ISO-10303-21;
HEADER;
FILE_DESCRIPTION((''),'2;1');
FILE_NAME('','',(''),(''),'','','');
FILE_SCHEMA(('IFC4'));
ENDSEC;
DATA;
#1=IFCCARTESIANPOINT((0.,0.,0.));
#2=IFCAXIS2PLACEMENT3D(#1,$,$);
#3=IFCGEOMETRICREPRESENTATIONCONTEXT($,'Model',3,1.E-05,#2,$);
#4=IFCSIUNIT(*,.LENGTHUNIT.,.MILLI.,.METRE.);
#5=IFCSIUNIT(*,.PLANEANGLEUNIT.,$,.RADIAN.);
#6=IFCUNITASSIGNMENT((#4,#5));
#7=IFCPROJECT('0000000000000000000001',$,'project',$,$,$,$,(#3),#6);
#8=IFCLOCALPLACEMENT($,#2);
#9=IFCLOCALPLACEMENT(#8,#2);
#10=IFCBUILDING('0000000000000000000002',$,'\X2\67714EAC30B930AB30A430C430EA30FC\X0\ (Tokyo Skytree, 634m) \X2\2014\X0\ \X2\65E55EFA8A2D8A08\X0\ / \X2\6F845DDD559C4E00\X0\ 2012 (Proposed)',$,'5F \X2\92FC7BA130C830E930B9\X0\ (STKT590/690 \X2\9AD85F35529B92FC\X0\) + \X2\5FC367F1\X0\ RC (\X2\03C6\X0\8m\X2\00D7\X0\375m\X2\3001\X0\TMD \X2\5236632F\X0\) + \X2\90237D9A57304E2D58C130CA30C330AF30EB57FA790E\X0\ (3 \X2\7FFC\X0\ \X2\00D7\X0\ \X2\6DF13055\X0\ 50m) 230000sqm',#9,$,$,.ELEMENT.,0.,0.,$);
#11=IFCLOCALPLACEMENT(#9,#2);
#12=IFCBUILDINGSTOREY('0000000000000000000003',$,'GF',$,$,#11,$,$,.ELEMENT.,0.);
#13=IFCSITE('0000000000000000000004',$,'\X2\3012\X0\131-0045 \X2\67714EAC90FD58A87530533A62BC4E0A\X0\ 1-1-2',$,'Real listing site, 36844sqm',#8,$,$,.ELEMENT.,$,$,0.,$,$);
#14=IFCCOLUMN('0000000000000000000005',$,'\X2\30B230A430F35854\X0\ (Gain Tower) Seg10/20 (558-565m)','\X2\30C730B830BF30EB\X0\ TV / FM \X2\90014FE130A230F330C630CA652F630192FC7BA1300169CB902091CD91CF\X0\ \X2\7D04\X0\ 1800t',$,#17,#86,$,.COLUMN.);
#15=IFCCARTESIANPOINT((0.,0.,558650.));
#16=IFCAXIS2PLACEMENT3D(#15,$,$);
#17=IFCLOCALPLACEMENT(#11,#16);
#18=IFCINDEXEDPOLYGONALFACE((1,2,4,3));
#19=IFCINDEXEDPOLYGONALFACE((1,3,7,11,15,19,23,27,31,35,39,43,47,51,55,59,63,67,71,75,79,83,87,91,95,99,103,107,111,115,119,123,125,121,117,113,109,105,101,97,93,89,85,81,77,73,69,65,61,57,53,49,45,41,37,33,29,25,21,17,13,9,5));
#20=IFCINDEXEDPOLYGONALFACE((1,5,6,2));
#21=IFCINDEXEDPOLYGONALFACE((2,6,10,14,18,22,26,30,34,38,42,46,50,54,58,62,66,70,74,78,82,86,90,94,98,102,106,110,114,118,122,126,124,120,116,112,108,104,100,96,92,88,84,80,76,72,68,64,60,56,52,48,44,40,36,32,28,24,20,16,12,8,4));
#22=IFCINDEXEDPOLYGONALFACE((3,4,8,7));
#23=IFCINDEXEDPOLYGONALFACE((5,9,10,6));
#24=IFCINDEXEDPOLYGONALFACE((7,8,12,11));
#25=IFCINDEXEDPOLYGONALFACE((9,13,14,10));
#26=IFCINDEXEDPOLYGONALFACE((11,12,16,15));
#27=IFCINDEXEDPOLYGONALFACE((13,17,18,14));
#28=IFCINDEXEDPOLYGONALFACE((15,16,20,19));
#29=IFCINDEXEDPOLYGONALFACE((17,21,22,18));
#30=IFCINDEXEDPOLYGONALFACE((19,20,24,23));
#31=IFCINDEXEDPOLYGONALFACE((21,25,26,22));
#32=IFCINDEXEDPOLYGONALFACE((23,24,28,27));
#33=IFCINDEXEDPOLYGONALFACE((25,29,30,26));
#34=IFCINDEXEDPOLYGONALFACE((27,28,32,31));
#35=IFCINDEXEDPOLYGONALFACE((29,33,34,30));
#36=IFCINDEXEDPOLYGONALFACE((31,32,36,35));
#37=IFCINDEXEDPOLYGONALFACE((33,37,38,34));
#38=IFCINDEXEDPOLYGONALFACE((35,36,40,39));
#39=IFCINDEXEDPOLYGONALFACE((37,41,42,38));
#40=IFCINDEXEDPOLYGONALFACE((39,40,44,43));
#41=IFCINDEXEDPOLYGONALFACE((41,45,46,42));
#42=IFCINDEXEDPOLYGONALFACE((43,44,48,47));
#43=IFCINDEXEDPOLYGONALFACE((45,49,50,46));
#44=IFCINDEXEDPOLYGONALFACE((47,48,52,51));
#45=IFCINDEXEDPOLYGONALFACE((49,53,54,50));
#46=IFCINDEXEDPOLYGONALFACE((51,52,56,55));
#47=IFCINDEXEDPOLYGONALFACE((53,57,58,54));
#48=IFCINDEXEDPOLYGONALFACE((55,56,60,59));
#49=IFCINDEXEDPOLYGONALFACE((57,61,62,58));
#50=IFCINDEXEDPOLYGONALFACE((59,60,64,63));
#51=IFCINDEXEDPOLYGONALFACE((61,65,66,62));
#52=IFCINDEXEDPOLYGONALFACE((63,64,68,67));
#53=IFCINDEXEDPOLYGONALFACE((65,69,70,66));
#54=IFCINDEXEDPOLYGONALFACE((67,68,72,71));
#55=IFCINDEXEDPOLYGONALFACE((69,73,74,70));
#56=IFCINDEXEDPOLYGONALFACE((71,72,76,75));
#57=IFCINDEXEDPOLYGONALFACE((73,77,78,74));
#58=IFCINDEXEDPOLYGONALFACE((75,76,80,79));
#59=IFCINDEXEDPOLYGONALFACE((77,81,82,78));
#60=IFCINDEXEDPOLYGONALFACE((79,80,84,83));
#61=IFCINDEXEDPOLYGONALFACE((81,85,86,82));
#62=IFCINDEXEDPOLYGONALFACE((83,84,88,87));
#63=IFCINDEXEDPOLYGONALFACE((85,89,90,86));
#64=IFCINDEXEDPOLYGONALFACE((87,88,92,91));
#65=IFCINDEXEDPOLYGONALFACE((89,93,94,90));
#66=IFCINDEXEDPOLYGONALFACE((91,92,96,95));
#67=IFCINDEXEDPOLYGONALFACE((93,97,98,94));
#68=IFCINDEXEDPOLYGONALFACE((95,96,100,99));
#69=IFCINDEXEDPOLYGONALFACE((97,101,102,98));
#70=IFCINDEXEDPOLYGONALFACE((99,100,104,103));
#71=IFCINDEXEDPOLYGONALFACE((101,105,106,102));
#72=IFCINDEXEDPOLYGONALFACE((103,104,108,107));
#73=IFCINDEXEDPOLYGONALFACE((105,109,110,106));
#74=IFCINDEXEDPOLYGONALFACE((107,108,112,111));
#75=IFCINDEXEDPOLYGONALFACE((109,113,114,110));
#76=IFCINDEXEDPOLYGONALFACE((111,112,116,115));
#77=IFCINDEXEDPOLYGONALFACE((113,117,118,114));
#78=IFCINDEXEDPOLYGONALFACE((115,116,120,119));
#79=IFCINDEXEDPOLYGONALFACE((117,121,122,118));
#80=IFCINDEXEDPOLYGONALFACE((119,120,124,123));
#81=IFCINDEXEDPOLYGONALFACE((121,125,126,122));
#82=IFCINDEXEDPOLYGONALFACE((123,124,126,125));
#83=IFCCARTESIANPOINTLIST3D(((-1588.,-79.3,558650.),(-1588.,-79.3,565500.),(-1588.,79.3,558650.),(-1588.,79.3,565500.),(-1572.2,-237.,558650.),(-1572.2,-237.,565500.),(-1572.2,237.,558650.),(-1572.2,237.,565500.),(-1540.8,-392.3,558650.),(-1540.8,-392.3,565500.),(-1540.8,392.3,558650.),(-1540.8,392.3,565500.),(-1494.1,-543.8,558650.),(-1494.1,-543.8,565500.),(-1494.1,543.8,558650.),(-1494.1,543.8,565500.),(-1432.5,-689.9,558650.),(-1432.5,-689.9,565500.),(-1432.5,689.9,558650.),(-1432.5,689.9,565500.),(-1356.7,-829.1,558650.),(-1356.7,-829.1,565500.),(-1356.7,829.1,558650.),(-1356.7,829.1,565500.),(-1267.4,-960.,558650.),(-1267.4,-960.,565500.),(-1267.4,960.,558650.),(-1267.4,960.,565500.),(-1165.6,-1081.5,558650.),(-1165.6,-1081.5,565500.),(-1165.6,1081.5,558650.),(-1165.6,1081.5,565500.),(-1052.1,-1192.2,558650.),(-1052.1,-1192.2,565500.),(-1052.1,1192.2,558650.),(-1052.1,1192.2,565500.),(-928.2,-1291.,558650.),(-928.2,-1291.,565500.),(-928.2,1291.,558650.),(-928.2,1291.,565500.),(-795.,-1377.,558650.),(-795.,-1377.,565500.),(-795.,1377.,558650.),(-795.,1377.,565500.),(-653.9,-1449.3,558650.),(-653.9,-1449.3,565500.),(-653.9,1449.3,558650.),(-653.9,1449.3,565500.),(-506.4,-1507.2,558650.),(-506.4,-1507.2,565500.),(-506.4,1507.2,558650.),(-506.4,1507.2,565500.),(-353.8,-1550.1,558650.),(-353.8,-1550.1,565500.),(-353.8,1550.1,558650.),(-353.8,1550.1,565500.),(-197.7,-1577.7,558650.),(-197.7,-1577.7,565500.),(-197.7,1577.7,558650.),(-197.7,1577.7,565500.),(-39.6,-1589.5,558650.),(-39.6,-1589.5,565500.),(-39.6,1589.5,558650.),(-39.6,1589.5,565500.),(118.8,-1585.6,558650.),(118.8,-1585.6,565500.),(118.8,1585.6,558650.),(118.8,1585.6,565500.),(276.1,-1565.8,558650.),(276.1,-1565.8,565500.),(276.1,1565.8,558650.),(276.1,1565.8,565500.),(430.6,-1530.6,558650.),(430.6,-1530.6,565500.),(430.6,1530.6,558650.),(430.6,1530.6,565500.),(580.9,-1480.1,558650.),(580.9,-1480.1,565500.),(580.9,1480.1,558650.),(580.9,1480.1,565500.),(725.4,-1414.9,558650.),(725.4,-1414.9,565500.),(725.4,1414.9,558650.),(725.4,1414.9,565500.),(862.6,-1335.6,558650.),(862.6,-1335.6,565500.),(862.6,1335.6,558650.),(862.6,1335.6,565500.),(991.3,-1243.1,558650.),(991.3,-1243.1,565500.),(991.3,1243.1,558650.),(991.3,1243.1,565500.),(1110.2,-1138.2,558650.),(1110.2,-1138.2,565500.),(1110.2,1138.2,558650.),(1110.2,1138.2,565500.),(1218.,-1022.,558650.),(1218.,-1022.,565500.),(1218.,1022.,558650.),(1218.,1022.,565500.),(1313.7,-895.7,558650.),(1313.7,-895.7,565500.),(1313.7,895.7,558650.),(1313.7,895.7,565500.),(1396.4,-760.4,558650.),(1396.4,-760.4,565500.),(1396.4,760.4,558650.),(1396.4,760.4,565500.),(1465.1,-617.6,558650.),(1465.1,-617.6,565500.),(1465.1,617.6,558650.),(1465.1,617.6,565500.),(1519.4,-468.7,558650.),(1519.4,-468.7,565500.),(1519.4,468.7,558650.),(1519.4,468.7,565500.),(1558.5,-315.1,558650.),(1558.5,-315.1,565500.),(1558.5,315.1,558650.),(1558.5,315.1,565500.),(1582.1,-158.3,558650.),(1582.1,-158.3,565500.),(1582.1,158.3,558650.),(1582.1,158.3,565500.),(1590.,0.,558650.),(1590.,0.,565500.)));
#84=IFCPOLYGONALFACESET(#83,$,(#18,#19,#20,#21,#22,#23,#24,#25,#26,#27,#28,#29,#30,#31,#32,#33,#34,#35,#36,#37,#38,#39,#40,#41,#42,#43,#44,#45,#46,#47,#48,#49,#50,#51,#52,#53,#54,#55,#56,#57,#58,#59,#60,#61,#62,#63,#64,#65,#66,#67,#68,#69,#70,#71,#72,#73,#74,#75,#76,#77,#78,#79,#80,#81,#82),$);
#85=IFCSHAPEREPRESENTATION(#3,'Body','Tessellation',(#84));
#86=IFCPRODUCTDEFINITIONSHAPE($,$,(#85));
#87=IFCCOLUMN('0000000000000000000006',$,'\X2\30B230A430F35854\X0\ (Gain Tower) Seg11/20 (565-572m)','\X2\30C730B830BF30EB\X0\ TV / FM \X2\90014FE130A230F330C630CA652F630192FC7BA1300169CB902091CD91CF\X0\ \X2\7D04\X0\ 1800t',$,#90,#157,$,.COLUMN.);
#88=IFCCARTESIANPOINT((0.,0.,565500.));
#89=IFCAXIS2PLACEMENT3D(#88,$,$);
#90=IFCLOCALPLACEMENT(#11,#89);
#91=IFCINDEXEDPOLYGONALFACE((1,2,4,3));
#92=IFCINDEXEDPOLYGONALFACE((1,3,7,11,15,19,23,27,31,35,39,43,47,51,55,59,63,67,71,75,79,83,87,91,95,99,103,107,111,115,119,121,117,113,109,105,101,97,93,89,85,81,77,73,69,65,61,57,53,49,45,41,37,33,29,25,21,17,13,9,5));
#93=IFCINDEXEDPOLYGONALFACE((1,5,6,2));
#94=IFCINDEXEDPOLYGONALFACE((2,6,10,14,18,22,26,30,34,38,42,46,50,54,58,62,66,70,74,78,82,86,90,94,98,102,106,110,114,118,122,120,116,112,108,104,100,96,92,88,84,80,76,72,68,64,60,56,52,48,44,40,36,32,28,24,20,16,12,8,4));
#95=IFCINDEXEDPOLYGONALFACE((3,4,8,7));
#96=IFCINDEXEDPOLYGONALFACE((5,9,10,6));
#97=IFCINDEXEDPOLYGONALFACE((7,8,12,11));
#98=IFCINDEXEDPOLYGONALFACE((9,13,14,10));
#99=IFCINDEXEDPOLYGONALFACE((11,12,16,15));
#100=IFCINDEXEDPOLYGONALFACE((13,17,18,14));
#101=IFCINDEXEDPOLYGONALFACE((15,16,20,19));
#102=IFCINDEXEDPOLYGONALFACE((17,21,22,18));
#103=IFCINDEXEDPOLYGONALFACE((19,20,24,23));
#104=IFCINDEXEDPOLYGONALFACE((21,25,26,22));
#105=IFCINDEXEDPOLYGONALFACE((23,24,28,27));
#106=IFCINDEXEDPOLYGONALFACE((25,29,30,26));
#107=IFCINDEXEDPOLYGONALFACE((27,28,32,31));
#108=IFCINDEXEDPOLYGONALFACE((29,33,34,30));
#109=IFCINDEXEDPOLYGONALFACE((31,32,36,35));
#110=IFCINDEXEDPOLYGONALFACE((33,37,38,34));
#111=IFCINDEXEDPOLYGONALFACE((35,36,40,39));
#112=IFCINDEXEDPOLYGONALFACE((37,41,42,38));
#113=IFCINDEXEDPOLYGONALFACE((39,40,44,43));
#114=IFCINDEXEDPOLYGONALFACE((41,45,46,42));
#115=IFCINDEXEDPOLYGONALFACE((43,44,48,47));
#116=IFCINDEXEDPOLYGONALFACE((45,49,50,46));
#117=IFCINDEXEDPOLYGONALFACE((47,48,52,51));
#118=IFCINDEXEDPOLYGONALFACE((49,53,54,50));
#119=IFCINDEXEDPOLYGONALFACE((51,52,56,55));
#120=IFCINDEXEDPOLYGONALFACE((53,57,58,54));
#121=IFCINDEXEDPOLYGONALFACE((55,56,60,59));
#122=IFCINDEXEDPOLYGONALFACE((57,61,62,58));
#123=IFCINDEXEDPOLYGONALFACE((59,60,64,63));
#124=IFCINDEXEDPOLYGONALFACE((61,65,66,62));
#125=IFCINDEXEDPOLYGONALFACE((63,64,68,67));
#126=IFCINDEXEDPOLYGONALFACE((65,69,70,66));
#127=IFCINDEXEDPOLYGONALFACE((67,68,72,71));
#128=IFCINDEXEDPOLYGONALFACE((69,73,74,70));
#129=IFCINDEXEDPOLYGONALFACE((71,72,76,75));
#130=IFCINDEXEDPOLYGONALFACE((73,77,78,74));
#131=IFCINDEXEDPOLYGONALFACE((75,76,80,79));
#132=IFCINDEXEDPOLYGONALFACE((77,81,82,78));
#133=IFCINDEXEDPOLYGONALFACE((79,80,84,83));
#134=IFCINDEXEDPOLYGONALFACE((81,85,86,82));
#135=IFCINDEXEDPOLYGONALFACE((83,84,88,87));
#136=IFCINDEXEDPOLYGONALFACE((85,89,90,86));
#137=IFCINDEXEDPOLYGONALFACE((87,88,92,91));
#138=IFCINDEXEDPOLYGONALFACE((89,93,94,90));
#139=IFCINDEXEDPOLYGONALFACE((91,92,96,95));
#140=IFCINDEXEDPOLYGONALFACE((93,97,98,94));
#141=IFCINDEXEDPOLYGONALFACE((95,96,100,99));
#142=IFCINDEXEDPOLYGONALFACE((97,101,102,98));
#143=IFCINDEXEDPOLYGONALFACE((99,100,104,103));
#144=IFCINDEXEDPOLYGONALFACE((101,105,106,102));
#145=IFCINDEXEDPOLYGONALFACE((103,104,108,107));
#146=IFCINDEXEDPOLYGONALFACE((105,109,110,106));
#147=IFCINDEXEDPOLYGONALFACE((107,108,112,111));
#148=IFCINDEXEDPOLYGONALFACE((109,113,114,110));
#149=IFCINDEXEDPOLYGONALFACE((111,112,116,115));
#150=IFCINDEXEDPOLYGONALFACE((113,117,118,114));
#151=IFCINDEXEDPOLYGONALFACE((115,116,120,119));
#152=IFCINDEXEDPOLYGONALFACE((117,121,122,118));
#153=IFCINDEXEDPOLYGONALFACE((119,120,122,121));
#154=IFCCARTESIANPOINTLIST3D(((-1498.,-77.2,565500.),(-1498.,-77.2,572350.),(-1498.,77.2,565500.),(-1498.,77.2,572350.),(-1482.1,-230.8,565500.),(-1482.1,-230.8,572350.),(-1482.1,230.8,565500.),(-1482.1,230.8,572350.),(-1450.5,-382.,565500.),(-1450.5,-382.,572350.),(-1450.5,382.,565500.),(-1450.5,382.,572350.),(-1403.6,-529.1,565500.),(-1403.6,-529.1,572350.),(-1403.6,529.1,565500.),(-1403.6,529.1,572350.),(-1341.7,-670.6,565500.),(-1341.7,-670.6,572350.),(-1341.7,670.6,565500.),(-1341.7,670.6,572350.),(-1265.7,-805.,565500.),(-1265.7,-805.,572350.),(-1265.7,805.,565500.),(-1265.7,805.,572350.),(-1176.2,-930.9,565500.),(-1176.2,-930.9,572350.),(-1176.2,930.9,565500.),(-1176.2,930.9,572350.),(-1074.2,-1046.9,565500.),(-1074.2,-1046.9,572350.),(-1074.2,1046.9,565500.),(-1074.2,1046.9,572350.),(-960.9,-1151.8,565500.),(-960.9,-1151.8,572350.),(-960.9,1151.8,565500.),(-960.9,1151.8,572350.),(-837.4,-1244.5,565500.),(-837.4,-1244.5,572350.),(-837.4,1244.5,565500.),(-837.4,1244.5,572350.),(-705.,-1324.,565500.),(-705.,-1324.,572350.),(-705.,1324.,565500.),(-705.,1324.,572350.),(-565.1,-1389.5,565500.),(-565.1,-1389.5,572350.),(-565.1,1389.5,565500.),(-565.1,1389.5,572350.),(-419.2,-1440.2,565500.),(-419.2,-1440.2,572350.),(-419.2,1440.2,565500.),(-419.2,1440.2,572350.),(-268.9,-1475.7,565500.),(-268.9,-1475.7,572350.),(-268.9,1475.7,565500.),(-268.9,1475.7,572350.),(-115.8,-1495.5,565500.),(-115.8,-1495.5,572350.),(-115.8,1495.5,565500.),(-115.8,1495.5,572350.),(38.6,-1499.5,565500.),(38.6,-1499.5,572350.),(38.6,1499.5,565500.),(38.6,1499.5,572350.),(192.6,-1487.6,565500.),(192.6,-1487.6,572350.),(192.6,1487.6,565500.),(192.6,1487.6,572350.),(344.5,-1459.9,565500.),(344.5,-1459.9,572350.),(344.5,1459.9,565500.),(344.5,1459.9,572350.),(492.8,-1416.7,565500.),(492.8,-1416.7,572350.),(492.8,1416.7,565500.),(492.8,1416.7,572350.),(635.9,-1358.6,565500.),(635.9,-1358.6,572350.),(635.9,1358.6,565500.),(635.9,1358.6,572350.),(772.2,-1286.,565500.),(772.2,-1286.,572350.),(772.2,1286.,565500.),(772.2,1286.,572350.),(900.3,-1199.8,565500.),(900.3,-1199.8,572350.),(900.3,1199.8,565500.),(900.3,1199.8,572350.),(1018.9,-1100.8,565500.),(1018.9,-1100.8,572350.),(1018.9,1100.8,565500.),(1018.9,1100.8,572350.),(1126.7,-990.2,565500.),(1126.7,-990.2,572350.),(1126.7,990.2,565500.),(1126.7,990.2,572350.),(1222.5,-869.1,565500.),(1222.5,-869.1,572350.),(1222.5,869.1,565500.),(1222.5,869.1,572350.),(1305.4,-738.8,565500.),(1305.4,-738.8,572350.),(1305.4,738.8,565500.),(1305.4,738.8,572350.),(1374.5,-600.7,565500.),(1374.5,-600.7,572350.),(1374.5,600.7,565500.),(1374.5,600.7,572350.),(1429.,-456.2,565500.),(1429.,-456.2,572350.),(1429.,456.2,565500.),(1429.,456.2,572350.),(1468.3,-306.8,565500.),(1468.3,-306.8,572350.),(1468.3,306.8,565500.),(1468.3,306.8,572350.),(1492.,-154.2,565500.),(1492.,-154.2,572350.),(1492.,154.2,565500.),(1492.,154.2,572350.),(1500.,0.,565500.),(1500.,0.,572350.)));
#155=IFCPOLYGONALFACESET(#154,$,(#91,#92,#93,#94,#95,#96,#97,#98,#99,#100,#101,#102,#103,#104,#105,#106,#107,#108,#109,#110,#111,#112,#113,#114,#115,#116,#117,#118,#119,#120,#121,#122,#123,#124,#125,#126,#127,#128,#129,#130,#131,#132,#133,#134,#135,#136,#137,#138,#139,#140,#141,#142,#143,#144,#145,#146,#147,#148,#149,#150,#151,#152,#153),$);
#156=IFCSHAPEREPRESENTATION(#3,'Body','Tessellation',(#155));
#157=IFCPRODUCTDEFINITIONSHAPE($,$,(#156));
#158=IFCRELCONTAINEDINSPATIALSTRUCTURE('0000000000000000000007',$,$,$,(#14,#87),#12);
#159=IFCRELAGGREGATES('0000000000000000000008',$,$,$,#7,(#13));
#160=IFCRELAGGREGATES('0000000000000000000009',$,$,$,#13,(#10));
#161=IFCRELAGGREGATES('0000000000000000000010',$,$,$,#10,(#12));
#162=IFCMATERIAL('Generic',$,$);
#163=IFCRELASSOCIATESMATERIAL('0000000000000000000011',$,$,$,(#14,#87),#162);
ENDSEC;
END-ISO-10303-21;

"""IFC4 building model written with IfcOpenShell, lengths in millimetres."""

from ifc_helpers import new_model, si_unit, frame, origin, origin_2d, place, context, project, spatial, circle, extrude, material, element, save


model = new_model("IFC4")

# Units and contexts
model_context = context("Model", 3, precision=1e-05, world=origin())
ifc_project = project(units=[si_unit("LENGTHUNIT", "METRE", prefix="MILLI"), si_unit("PLANEANGLEUNIT", "RADIAN")], contexts=[model_context])

# Site, building, storey
site_placement = place(None, origin())
site = spatial("IfcSite", under=ifc_project, at=site_placement, Name="〒131-0045 東京都墨田区押上 1-1-2", ObjectType="Real listing site, 36844sqm", CompositionType="ELEMENT", RefElevation=0.0)
building_placement = place(site_placement, origin())
building = spatial("IfcBuilding", under=site, at=building_placement, Name="東京スカイツリー (Tokyo Skytree, 634m) — 日建設計 / 澄川喜一 2012 (Proposed)", ObjectType="5F 鋼管トラス (STKT590/690 高張力鋼) + 心柱 RC (φ8m×375m、TMD 制振) + 連続地中壁ナックル基礎 (3 翼 × 深さ 50m) 230000sqm", CompositionType="ELEMENT", ElevationOfRefHeight=0.0, ElevationOfTerrain=0.0)
storey_placement = place(building_placement, origin())
storey = spatial("IfcBuildingStorey", under=building, at=storey_placement, Name="GF", CompositionType="ELEMENT", Elevation=0.0)

# Columns
ifc_material = material(Name="Generic")
column_1_placement = place(storey_placement, frame((0.0, 0.0, 558650.0)))
element("IfcColumn", 1, at=column_1_placement, inside=storey, material=ifc_material, Name="ゲイン塔 (Gain Tower) Seg10/20 (558-565m)", Description="デジタル TV / FM 送信アンテナ支持鋼管、構造重量 約 1800t", PredefinedType="COLUMN", context=model_context, shape_type="SweptSolid", body=[
    extrude(circle(Radius=1590.0, at=origin_2d()), frame((0.0, 0.0, 558650.0)), (0.0, 0.0, 1.0), 6850.0),
])
column_2_placement = place(storey_placement, frame((0.0, 0.0, 565500.0)))
element("IfcColumn", 2, at=column_2_placement, inside=storey, material=ifc_material, Name="ゲイン塔 (Gain Tower) Seg11/20 (565-572m)", Description="デジタル TV / FM 送信アンテナ支持鋼管、構造重量 約 1800t", PredefinedType="COLUMN", context=model_context, shape_type="SweptSolid", body=[
    extrude(circle(Radius=1500.0, at=origin_2d()), frame((0.0, 0.0, 565500.0)), (0.0, 0.0, 1.0), 6850.0),
])

save(model, "model.ifc")
